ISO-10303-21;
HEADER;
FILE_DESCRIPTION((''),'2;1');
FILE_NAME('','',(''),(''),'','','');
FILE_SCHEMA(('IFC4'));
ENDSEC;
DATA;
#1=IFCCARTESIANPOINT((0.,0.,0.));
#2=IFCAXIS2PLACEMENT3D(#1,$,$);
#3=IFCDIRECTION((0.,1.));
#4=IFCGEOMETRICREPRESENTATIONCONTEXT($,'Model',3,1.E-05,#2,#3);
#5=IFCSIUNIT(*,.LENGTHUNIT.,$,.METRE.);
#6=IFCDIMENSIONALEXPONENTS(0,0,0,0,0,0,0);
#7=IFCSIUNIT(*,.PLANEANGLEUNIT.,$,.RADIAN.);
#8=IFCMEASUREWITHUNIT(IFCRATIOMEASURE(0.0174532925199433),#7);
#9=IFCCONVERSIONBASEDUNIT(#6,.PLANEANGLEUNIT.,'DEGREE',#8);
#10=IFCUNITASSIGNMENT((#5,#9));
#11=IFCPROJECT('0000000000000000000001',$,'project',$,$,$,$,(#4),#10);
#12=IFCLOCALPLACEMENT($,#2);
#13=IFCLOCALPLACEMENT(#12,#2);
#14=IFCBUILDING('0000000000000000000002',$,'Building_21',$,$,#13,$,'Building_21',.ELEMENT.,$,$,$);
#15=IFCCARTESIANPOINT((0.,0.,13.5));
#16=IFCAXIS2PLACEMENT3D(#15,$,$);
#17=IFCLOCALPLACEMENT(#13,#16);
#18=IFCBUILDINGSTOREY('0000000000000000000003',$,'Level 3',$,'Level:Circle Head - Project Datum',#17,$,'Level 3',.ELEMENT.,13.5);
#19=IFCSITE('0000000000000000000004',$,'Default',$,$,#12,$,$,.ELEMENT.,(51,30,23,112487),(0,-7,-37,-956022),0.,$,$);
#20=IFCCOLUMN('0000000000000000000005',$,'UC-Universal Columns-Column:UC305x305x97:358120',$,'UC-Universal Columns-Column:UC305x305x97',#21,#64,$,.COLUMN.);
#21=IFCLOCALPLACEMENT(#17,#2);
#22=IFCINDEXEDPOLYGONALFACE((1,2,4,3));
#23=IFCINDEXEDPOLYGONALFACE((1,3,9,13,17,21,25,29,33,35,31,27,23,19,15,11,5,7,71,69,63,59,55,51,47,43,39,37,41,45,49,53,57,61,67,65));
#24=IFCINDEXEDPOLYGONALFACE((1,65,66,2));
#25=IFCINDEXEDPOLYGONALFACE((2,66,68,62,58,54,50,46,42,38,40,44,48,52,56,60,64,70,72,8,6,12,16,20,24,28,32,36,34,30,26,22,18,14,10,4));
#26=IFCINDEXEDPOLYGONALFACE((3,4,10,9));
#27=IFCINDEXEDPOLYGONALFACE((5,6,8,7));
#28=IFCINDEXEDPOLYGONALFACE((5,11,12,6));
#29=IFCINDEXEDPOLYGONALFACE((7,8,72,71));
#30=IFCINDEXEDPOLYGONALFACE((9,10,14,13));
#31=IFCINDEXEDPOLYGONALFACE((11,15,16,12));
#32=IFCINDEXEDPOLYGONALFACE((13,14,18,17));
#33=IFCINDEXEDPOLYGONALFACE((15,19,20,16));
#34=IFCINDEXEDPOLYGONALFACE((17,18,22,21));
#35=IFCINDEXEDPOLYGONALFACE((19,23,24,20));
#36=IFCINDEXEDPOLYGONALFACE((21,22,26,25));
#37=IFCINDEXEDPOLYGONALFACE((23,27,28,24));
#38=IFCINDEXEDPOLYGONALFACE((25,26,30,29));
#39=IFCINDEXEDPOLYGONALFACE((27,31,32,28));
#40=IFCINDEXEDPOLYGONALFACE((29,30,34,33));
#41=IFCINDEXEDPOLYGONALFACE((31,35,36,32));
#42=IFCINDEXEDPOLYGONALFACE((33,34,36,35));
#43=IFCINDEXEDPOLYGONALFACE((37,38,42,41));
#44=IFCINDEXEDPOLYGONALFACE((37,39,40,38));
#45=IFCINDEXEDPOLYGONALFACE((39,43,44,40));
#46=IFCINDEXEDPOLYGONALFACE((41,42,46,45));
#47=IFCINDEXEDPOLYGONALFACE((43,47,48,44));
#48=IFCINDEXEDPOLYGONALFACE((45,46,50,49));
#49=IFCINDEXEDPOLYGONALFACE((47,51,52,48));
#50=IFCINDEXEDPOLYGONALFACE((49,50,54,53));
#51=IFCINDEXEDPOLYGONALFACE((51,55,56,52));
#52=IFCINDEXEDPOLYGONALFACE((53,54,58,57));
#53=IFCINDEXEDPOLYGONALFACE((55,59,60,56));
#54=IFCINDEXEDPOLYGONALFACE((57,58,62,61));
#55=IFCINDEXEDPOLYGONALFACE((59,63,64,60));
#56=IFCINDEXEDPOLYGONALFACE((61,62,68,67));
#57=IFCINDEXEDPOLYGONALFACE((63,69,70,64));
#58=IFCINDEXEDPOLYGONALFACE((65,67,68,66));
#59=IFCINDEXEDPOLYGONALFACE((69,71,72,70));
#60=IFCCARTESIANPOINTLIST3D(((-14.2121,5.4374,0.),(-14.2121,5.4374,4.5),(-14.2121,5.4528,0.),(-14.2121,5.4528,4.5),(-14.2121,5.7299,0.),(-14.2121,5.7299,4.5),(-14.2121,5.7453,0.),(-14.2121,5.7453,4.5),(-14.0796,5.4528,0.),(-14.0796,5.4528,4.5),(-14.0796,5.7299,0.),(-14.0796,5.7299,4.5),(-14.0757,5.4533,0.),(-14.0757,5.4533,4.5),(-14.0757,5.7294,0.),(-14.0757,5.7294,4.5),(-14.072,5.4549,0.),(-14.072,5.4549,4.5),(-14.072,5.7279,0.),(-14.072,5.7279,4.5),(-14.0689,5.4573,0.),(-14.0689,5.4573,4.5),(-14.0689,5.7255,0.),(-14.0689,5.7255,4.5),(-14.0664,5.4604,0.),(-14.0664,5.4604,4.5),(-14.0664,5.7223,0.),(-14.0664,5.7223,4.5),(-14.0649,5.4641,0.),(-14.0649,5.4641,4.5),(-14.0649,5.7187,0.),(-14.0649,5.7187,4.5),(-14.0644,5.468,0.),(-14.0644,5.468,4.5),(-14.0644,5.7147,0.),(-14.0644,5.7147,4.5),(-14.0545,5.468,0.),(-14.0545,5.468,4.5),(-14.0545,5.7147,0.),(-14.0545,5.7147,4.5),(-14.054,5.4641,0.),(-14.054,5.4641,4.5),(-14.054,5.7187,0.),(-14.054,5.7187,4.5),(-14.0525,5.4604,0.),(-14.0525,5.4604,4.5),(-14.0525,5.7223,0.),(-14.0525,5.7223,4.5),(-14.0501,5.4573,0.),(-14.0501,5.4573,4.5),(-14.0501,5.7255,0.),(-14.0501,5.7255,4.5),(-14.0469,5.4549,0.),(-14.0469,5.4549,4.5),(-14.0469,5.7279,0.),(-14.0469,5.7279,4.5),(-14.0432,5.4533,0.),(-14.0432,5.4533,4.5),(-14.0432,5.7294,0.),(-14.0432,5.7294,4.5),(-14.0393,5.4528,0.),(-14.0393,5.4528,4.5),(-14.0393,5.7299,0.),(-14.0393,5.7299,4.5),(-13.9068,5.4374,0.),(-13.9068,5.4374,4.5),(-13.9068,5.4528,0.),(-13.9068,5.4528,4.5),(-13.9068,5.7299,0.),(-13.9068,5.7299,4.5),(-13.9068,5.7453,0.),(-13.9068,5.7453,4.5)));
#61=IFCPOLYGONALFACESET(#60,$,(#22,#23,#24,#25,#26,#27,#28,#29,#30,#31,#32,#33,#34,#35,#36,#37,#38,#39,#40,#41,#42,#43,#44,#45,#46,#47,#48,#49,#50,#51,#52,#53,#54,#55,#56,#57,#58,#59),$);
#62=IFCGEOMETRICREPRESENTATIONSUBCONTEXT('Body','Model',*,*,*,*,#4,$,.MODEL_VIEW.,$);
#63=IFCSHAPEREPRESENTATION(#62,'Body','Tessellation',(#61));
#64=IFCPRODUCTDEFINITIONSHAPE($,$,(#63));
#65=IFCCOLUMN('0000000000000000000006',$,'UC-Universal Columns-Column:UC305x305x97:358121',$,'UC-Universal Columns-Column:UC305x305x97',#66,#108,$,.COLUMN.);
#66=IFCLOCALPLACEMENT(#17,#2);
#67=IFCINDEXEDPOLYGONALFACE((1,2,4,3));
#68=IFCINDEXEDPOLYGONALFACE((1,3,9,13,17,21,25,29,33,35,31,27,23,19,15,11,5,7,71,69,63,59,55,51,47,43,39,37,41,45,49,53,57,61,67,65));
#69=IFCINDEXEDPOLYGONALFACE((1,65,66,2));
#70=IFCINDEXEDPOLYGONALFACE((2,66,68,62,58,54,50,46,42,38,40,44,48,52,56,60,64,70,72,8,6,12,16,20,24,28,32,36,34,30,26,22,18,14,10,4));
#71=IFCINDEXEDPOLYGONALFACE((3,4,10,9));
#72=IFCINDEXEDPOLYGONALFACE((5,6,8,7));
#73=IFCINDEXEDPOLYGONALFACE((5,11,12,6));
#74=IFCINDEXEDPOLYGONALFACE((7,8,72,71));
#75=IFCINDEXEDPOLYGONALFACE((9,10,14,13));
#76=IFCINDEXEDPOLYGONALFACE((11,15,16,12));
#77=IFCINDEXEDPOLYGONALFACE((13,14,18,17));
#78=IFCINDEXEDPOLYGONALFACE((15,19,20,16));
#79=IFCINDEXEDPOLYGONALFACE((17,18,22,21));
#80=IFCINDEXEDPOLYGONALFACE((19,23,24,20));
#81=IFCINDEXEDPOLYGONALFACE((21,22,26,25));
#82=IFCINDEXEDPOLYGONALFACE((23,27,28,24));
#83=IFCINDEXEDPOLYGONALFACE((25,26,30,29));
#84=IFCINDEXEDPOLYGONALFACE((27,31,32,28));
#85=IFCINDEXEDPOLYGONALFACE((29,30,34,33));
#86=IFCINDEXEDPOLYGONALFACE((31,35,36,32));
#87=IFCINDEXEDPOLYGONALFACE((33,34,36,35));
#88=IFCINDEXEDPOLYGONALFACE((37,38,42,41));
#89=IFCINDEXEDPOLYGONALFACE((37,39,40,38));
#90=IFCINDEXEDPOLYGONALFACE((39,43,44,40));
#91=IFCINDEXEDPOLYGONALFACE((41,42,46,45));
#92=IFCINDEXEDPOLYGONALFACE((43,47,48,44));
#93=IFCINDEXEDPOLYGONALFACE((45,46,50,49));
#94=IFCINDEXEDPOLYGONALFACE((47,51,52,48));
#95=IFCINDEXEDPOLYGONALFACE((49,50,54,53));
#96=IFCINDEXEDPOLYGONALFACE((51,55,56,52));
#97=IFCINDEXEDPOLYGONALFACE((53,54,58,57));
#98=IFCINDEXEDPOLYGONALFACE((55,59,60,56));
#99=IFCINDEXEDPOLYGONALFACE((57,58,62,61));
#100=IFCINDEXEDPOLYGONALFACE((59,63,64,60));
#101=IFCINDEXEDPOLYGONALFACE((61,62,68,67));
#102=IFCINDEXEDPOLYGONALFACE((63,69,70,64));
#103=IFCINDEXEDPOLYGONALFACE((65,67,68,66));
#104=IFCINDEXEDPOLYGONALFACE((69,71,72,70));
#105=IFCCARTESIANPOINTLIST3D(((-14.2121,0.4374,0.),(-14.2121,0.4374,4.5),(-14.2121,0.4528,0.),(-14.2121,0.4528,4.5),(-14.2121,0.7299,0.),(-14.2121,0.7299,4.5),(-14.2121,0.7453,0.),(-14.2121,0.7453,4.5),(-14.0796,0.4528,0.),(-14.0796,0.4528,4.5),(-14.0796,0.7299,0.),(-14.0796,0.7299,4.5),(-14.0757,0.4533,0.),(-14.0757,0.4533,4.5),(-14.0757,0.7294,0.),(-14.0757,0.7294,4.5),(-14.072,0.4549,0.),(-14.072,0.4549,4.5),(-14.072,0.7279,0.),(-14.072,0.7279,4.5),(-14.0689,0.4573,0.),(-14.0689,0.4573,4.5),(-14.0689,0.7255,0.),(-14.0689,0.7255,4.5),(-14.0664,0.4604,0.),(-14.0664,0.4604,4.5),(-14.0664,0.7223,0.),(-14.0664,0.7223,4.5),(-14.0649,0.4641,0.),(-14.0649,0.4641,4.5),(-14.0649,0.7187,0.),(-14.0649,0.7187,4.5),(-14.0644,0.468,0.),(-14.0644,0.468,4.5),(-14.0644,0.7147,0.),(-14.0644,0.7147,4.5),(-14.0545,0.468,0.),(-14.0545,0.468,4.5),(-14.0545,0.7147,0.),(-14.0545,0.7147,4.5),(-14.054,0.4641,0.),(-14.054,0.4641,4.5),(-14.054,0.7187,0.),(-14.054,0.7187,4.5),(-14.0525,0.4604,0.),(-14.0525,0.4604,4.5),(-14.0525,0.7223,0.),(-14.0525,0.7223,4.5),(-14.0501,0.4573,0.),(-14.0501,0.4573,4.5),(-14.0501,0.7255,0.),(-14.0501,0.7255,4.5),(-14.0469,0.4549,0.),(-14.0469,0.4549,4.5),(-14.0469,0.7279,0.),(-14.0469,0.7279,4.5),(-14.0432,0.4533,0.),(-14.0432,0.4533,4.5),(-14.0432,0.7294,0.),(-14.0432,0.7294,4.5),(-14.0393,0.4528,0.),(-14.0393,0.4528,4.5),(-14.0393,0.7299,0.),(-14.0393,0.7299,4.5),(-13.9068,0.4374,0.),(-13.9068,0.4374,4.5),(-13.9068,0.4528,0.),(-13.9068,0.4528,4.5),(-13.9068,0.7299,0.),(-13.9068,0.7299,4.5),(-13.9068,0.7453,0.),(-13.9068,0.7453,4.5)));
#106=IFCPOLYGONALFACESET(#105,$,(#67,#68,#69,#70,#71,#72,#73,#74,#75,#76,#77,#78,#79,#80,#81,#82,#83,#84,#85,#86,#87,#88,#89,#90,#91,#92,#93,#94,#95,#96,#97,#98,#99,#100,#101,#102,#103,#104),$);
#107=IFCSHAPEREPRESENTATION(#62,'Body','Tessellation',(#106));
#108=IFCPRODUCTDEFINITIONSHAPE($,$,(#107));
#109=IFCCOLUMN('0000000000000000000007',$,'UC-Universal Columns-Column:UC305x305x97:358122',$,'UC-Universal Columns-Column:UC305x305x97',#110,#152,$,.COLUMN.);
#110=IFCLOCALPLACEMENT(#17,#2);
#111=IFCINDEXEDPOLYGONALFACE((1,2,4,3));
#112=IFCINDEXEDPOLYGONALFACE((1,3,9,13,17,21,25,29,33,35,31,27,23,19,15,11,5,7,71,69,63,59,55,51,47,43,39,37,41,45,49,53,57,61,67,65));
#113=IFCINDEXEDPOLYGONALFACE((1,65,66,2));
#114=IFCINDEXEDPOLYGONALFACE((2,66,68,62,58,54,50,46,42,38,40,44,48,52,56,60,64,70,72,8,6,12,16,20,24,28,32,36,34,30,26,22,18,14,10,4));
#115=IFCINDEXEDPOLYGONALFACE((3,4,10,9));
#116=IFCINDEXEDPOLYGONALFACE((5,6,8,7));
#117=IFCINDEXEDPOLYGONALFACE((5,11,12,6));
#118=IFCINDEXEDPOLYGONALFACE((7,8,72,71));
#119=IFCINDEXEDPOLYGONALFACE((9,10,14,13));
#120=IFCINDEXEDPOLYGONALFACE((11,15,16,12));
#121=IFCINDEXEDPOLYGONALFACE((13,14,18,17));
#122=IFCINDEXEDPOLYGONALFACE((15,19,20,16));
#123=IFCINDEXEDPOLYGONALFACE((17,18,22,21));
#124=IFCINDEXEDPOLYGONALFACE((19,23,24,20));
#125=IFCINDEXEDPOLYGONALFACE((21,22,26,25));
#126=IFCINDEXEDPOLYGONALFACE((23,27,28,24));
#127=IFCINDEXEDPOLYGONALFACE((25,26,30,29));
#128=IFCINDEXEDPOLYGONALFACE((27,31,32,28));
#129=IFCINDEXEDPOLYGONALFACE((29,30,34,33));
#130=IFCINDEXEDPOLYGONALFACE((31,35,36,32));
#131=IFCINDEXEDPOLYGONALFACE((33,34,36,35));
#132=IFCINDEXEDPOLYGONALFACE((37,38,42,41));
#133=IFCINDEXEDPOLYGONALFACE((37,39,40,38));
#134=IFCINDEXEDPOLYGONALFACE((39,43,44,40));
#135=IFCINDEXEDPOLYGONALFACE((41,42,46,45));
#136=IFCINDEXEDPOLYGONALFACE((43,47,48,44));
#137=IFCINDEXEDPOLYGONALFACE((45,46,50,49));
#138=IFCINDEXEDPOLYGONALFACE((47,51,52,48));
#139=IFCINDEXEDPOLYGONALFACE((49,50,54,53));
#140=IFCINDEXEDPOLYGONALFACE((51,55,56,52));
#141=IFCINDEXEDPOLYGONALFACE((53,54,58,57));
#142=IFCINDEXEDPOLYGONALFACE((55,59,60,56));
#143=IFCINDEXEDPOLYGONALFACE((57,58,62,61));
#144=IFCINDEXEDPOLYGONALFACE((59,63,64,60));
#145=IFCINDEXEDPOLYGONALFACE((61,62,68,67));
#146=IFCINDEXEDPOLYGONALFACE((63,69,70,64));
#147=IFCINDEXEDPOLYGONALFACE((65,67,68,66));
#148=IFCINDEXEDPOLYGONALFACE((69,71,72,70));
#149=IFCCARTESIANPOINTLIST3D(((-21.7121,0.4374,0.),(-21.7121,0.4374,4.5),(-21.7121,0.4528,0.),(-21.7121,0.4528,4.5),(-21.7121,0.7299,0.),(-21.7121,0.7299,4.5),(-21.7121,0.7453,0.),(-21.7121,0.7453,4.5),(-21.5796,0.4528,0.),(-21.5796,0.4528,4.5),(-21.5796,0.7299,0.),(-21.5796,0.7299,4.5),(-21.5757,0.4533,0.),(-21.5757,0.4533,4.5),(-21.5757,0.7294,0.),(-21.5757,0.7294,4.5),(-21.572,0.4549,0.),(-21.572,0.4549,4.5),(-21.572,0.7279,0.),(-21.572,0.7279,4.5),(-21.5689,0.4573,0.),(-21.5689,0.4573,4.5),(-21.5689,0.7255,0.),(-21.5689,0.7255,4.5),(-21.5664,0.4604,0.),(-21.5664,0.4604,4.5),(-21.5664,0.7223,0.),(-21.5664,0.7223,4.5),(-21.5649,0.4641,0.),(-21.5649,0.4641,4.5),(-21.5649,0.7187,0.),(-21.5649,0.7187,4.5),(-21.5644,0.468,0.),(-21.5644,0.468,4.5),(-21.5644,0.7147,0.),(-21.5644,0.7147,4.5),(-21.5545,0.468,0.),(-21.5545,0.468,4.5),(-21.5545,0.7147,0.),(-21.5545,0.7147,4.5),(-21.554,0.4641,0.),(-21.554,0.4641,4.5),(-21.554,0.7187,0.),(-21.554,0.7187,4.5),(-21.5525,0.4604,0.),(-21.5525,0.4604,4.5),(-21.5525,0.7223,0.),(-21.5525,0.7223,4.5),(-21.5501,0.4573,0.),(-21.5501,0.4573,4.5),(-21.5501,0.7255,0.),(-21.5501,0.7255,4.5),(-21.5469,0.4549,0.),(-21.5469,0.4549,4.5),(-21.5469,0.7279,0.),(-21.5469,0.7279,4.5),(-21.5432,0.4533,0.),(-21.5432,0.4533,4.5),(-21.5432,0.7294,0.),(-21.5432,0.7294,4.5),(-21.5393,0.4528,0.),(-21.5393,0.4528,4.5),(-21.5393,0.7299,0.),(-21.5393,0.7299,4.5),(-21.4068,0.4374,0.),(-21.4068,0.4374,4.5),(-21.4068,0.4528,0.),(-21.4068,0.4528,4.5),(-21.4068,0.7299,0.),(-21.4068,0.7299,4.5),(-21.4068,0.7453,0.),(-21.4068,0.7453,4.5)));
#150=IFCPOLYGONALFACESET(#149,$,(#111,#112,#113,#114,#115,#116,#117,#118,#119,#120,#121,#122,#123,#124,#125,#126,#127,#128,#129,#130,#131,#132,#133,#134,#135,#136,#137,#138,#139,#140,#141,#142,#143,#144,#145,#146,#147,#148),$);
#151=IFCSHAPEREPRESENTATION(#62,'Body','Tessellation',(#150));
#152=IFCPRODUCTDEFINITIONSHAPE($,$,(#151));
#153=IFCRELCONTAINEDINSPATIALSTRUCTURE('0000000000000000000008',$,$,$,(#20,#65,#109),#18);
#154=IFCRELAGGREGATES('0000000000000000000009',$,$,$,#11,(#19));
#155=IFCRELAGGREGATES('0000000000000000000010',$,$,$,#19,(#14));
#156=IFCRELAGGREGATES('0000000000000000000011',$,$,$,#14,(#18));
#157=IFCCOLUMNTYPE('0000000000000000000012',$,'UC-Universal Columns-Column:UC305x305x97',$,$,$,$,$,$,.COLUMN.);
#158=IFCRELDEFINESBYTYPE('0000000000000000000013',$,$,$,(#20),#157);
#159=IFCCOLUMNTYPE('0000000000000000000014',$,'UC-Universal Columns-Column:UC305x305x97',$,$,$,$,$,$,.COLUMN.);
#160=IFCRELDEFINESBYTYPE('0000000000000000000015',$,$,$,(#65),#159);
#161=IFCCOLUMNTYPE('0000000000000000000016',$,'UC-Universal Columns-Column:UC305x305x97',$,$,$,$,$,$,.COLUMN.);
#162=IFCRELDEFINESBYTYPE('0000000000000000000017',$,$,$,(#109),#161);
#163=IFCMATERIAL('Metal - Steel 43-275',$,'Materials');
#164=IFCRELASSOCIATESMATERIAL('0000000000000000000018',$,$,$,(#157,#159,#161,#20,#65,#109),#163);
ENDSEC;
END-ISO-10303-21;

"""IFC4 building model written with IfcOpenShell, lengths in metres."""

from ifc_helpers import new_model, entity, si_unit, converted_unit, direction, frame, frame_2d, origin, place, context, subcontext, project, spatial, polyline, circle_curve, parameter, trimmed, segment, composite_curve, i_section, outline, extrude, source, transform, mapped, material, material_profile, profile_set, profile_usage, type_object, type_shapes, element, save


model = new_model("IFC4")

# Units and contexts
model_context = context("Model", 3, precision=1e-05, world=origin(), true_north=direction((0.0, 1.0)))
body_context = subcontext(model_context, "Body", "Model", "MODEL_VIEW")
ifc_project = project(units=[si_unit("LENGTHUNIT", "METRE"), converted_unit("PLANEANGLEUNIT", "DEGREE", entity("IfcRatioMeasure", 0.0174532925199433), si_unit("PLANEANGLEUNIT", "RADIAN"), dimensions=[0, 0, 0, 0, 0, 0, 0])], contexts=[model_context])

# Site, building, storey
site_placement = place(None, origin())
site = spatial("IfcSite", under=ifc_project, at=site_placement, Name="Default", CompositionType="ELEMENT", RefLatitude=(51, 30, 23, 112487), RefLongitude=(0, -7, -37, -956022), RefElevation=0.0)
building_placement = place(site_placement, origin())
building = spatial("IfcBuilding", under=site, at=building_placement, Name="Building_21", LongName="Building_21", CompositionType="ELEMENT")
storey_placement = place(building_placement, frame((0.0, 0.0, 13.5)))
storey = spatial("IfcBuildingStorey", under=building, at=storey_placement, Name="Level 3", ObjectType="Level:Circle Head - Project Datum", LongName="Level 3", CompositionType="ELEMENT", Elevation=13.5)

# Columns
ifc_material_1 = material(Name="Metal - Steel 43-275", Category="Materials")
ifc_material_profile_1 = material_profile(ifc_material_1, outline(composite_curve([segment(polyline([(-0.1527, 0.154, 0.0), (0.1527, 0.154, 0.0)]), True, "CONTINUOUS"), segment(polyline([(0.1527, 0.154, 0.0), (0.1527, 0.1386, 0.0)]), True, "CONTINUOUS"), segment(polyline([(0.1527, 0.1386, 0.0), (0.0201, 0.1386, 0.0)]), True, "CONTINUOUS"), segment(trimmed(circle_curve(frame((0.0201, 0.1234, 0.0)), 0.0152), [parameter(90.0)], [parameter(180.0)], True, "PARAMETER"), True, "CONTINUOUS"), segment(polyline([(0.0049, 0.1234, 0.0), (0.0049, -0.1234, 0.0)]), True, "CONTINUOUS"), segment(trimmed(circle_curve(frame((0.0201, -0.1234, 0.0)), 0.0152), [parameter(180.0)], [parameter(270.0)], True, "PARAMETER"), True, "CONTINUOUS"), segment(polyline([(0.0201, -0.1386, 0.0), (0.1527, -0.1386, 0.0)]), True, "CONTINUOUS"), segment(polyline([(0.1527, -0.1386, 0.0), (0.1527, -0.154, 0.0)]), True, "CONTINUOUS"), segment(polyline([(0.1527, -0.154, 0.0), (-0.1527, -0.154, 0.0)]), True, "CONTINUOUS"), segment(polyline([(-0.1527, -0.154, 0.0), (-0.1527, -0.1386, 0.0)]), True, "CONTINUOUS"), segment(polyline([(-0.1527, -0.1386, 0.0), (-0.0201, -0.1386, 0.0)]), True, "CONTINUOUS"), segment(trimmed(circle_curve(frame((-0.0201, -0.1234, 0.0)), 0.0152), [parameter(270.0)], [parameter(0.0)], True, "PARAMETER"), True, "CONTINUOUS"), segment(polyline([(-0.0049, -0.1234, 0.0), (-0.005, 0.1234, 0.0)]), True, "CONTINUOUS"), segment(trimmed(circle_curve(frame((-0.0201, 0.1234, 0.0)), 0.0152), [parameter(0.0)], [parameter(90.0)], True, "PARAMETER"), True, "CONTINUOUS"), segment(polyline([(-0.0201, 0.1386, 0.0), (-0.1527, 0.1386, 0.0)]), True, "CONTINUOUS"), segment(polyline([(-0.1527, 0.1386, 0.0), (-0.1527, 0.154, 0.0)]), True, "CONTINUOUS")], self_intersect=False), kind="CURVE"), Name="UC305x305x97")
ifc_material_profile_2 = material_profile(ifc_material_1, outline(composite_curve([segment(polyline([(0.1527, 0.154, 0.0), (0.1527, 0.1386, 0.0)]), True, "CONTINUOUS"), segment(polyline([(0.1527, 0.1386, 0.0), (0.0049, 0.1386, 0.0)]), True, "CONTINUOUS"), segment(polyline([(0.0049, 0.1386, 0.0), (0.0049, -0.1386, 0.0)]), True, "CONTINUOUS"), segment(polyline([(0.0049, -0.1386, 0.0), (0.1527, -0.1386, 0.0)]), True, "CONTINUOUS"), segment(polyline([(0.1527, -0.1386, 0.0), (0.1527, -0.154, 0.0)]), True, "CONTINUOUS"), segment(polyline([(0.1527, -0.154, 0.0), (-0.1527, -0.154, 0.0)]), True, "CONTINUOUS"), segment(polyline([(-0.1527, -0.154, 0.0), (-0.1527, -0.1386, 0.0)]), True, "CONTINUOUS"), segment(polyline([(-0.1527, -0.1386, 0.0), (-0.005, -0.1386, 0.0)]), True, "CONTINUOUS"), segment(polyline([(-0.005, -0.1386, 0.0), (-0.005, 0.1386, 0.0)]), True, "CONTINUOUS"), segment(polyline([(-0.005, 0.1386, 0.0), (-0.1527, 0.1386, 0.0)]), True, "CONTINUOUS"), segment(polyline([(-0.1527, 0.1386, 0.0), (-0.1527, 0.154, 0.0)]), True, "CONTINUOUS"), segment(polyline([(-0.1527, 0.154, 0.0), (0.1527, 0.154, 0.0)]), True, "CONTINUOUS")], self_intersect=False), kind="CURVE"), Name="UC305x305x97")
ifc_profile_set = profile_set([ifc_material_profile_1, ifc_material_profile_2], Name="UC305x305x97")
ifc_profile_usage_1 = profile_usage(ifc_profile_set)
column_type_1 = type_object("IfcColumnType", Name="UC-Universal Columns-Column:UC305x305x97", PredefinedType="COLUMN", material=ifc_profile_set)
shared_shape_1 = source(origin(), body_context, "Body", "SweptSolid", [
    extrude(i_section(OverallWidth=0.3053, OverallDepth=0.3079, WebThickness=0.0099, FlangeThickness=0.0154, FilletRadius=0.0152, at=frame_2d((0.0, 0.0), x_axis=(0.0, 1.0))), frame((-14.0595, 5.5914, 13.5), z_axis=(0.0, 0.0, 1.0), x_axis=(0.0, -1.0, 0.0)), (0.0, 0.0, 1.0), 4.5),
])
type_shapes(column_type_1, [shared_shape_1])
column_1_placement = place(storey_placement, frame((0.0, 0.0, -13.5)))
element("IfcColumn", 1, at=column_1_placement, inside=storey, type_object=column_type_1, material=ifc_profile_usage_1, Name="UC-Universal Columns-Column:UC305x305x97:358120", ObjectType="UC-Universal Columns-Column:UC305x305x97", PredefinedType="COLUMN", context=body_context, shape_type="MappedRepresentation", body=[
    mapped(shared_shape_1, transform((0.0, 0.0, 0.0), scale=1.0)),
])
ifc_profile_usage_2 = profile_usage(ifc_profile_set)
column_type_2 = type_object("IfcColumnType", Name="UC-Universal Columns-Column:UC305x305x97", PredefinedType="COLUMN", material=ifc_profile_set)
shared_shape_2 = source(origin(), body_context, "Body", "SweptSolid", [
    extrude(i_section(OverallWidth=0.3053, OverallDepth=0.3079, WebThickness=0.0099, FlangeThickness=0.0154, FilletRadius=0.0152, at=frame_2d((0.0, 0.0), x_axis=(0.0, 1.0))), frame((-14.0595, 0.5914, 13.5), z_axis=(0.0, 0.0, 1.0), x_axis=(0.0, -1.0, 0.0)), (0.0, 0.0, 1.0), 4.5),
])
type_shapes(column_type_2, [shared_shape_2])
column_2_placement = place(storey_placement, frame((0.0, 0.0, -13.5)))
element("IfcColumn", 2, at=column_2_placement, inside=storey, type_object=column_type_2, material=ifc_profile_usage_2, Name="UC-Universal Columns-Column:UC305x305x97:358121", ObjectType="UC-Universal Columns-Column:UC305x305x97", PredefinedType="COLUMN", context=body_context, shape_type="MappedRepresentation", body=[
    mapped(shared_shape_2, transform((0.0, 0.0, 0.0), scale=1.0)),
])
ifc_profile_usage_3 = profile_usage(ifc_profile_set)
column_type_3 = type_object("IfcColumnType", Name="UC-Universal Columns-Column:UC305x305x97", PredefinedType="COLUMN", material=ifc_profile_set)
shared_shape_3 = source(origin(), body_context, "Body", "SweptSolid", [
    extrude(i_section(OverallWidth=0.3053, OverallDepth=0.3079, WebThickness=0.0099, FlangeThickness=0.0154, FilletRadius=0.0152, at=frame_2d((0.0, 0.0), x_axis=(0.0, 1.0))), frame((-21.5595, 0.5914, 13.5), z_axis=(0.0, 0.0, 1.0), x_axis=(0.0, -1.0, 0.0)), (0.0, 0.0, 1.0), 4.5),
])
type_shapes(column_type_3, [shared_shape_3])
column_3_placement = place(storey_placement, frame((0.0, 0.0, -13.5)))
element("IfcColumn", 3, at=column_3_placement, inside=storey, type_object=column_type_3, material=ifc_profile_usage_3, Name="UC-Universal Columns-Column:UC305x305x97:358122", ObjectType="UC-Universal Columns-Column:UC305x305x97", PredefinedType="COLUMN", context=body_context, shape_type="MappedRepresentation", body=[
    mapped(shared_shape_3, transform((0.0, 0.0, 0.0), scale=1.0)),
])

save(model, "model.ifc")
